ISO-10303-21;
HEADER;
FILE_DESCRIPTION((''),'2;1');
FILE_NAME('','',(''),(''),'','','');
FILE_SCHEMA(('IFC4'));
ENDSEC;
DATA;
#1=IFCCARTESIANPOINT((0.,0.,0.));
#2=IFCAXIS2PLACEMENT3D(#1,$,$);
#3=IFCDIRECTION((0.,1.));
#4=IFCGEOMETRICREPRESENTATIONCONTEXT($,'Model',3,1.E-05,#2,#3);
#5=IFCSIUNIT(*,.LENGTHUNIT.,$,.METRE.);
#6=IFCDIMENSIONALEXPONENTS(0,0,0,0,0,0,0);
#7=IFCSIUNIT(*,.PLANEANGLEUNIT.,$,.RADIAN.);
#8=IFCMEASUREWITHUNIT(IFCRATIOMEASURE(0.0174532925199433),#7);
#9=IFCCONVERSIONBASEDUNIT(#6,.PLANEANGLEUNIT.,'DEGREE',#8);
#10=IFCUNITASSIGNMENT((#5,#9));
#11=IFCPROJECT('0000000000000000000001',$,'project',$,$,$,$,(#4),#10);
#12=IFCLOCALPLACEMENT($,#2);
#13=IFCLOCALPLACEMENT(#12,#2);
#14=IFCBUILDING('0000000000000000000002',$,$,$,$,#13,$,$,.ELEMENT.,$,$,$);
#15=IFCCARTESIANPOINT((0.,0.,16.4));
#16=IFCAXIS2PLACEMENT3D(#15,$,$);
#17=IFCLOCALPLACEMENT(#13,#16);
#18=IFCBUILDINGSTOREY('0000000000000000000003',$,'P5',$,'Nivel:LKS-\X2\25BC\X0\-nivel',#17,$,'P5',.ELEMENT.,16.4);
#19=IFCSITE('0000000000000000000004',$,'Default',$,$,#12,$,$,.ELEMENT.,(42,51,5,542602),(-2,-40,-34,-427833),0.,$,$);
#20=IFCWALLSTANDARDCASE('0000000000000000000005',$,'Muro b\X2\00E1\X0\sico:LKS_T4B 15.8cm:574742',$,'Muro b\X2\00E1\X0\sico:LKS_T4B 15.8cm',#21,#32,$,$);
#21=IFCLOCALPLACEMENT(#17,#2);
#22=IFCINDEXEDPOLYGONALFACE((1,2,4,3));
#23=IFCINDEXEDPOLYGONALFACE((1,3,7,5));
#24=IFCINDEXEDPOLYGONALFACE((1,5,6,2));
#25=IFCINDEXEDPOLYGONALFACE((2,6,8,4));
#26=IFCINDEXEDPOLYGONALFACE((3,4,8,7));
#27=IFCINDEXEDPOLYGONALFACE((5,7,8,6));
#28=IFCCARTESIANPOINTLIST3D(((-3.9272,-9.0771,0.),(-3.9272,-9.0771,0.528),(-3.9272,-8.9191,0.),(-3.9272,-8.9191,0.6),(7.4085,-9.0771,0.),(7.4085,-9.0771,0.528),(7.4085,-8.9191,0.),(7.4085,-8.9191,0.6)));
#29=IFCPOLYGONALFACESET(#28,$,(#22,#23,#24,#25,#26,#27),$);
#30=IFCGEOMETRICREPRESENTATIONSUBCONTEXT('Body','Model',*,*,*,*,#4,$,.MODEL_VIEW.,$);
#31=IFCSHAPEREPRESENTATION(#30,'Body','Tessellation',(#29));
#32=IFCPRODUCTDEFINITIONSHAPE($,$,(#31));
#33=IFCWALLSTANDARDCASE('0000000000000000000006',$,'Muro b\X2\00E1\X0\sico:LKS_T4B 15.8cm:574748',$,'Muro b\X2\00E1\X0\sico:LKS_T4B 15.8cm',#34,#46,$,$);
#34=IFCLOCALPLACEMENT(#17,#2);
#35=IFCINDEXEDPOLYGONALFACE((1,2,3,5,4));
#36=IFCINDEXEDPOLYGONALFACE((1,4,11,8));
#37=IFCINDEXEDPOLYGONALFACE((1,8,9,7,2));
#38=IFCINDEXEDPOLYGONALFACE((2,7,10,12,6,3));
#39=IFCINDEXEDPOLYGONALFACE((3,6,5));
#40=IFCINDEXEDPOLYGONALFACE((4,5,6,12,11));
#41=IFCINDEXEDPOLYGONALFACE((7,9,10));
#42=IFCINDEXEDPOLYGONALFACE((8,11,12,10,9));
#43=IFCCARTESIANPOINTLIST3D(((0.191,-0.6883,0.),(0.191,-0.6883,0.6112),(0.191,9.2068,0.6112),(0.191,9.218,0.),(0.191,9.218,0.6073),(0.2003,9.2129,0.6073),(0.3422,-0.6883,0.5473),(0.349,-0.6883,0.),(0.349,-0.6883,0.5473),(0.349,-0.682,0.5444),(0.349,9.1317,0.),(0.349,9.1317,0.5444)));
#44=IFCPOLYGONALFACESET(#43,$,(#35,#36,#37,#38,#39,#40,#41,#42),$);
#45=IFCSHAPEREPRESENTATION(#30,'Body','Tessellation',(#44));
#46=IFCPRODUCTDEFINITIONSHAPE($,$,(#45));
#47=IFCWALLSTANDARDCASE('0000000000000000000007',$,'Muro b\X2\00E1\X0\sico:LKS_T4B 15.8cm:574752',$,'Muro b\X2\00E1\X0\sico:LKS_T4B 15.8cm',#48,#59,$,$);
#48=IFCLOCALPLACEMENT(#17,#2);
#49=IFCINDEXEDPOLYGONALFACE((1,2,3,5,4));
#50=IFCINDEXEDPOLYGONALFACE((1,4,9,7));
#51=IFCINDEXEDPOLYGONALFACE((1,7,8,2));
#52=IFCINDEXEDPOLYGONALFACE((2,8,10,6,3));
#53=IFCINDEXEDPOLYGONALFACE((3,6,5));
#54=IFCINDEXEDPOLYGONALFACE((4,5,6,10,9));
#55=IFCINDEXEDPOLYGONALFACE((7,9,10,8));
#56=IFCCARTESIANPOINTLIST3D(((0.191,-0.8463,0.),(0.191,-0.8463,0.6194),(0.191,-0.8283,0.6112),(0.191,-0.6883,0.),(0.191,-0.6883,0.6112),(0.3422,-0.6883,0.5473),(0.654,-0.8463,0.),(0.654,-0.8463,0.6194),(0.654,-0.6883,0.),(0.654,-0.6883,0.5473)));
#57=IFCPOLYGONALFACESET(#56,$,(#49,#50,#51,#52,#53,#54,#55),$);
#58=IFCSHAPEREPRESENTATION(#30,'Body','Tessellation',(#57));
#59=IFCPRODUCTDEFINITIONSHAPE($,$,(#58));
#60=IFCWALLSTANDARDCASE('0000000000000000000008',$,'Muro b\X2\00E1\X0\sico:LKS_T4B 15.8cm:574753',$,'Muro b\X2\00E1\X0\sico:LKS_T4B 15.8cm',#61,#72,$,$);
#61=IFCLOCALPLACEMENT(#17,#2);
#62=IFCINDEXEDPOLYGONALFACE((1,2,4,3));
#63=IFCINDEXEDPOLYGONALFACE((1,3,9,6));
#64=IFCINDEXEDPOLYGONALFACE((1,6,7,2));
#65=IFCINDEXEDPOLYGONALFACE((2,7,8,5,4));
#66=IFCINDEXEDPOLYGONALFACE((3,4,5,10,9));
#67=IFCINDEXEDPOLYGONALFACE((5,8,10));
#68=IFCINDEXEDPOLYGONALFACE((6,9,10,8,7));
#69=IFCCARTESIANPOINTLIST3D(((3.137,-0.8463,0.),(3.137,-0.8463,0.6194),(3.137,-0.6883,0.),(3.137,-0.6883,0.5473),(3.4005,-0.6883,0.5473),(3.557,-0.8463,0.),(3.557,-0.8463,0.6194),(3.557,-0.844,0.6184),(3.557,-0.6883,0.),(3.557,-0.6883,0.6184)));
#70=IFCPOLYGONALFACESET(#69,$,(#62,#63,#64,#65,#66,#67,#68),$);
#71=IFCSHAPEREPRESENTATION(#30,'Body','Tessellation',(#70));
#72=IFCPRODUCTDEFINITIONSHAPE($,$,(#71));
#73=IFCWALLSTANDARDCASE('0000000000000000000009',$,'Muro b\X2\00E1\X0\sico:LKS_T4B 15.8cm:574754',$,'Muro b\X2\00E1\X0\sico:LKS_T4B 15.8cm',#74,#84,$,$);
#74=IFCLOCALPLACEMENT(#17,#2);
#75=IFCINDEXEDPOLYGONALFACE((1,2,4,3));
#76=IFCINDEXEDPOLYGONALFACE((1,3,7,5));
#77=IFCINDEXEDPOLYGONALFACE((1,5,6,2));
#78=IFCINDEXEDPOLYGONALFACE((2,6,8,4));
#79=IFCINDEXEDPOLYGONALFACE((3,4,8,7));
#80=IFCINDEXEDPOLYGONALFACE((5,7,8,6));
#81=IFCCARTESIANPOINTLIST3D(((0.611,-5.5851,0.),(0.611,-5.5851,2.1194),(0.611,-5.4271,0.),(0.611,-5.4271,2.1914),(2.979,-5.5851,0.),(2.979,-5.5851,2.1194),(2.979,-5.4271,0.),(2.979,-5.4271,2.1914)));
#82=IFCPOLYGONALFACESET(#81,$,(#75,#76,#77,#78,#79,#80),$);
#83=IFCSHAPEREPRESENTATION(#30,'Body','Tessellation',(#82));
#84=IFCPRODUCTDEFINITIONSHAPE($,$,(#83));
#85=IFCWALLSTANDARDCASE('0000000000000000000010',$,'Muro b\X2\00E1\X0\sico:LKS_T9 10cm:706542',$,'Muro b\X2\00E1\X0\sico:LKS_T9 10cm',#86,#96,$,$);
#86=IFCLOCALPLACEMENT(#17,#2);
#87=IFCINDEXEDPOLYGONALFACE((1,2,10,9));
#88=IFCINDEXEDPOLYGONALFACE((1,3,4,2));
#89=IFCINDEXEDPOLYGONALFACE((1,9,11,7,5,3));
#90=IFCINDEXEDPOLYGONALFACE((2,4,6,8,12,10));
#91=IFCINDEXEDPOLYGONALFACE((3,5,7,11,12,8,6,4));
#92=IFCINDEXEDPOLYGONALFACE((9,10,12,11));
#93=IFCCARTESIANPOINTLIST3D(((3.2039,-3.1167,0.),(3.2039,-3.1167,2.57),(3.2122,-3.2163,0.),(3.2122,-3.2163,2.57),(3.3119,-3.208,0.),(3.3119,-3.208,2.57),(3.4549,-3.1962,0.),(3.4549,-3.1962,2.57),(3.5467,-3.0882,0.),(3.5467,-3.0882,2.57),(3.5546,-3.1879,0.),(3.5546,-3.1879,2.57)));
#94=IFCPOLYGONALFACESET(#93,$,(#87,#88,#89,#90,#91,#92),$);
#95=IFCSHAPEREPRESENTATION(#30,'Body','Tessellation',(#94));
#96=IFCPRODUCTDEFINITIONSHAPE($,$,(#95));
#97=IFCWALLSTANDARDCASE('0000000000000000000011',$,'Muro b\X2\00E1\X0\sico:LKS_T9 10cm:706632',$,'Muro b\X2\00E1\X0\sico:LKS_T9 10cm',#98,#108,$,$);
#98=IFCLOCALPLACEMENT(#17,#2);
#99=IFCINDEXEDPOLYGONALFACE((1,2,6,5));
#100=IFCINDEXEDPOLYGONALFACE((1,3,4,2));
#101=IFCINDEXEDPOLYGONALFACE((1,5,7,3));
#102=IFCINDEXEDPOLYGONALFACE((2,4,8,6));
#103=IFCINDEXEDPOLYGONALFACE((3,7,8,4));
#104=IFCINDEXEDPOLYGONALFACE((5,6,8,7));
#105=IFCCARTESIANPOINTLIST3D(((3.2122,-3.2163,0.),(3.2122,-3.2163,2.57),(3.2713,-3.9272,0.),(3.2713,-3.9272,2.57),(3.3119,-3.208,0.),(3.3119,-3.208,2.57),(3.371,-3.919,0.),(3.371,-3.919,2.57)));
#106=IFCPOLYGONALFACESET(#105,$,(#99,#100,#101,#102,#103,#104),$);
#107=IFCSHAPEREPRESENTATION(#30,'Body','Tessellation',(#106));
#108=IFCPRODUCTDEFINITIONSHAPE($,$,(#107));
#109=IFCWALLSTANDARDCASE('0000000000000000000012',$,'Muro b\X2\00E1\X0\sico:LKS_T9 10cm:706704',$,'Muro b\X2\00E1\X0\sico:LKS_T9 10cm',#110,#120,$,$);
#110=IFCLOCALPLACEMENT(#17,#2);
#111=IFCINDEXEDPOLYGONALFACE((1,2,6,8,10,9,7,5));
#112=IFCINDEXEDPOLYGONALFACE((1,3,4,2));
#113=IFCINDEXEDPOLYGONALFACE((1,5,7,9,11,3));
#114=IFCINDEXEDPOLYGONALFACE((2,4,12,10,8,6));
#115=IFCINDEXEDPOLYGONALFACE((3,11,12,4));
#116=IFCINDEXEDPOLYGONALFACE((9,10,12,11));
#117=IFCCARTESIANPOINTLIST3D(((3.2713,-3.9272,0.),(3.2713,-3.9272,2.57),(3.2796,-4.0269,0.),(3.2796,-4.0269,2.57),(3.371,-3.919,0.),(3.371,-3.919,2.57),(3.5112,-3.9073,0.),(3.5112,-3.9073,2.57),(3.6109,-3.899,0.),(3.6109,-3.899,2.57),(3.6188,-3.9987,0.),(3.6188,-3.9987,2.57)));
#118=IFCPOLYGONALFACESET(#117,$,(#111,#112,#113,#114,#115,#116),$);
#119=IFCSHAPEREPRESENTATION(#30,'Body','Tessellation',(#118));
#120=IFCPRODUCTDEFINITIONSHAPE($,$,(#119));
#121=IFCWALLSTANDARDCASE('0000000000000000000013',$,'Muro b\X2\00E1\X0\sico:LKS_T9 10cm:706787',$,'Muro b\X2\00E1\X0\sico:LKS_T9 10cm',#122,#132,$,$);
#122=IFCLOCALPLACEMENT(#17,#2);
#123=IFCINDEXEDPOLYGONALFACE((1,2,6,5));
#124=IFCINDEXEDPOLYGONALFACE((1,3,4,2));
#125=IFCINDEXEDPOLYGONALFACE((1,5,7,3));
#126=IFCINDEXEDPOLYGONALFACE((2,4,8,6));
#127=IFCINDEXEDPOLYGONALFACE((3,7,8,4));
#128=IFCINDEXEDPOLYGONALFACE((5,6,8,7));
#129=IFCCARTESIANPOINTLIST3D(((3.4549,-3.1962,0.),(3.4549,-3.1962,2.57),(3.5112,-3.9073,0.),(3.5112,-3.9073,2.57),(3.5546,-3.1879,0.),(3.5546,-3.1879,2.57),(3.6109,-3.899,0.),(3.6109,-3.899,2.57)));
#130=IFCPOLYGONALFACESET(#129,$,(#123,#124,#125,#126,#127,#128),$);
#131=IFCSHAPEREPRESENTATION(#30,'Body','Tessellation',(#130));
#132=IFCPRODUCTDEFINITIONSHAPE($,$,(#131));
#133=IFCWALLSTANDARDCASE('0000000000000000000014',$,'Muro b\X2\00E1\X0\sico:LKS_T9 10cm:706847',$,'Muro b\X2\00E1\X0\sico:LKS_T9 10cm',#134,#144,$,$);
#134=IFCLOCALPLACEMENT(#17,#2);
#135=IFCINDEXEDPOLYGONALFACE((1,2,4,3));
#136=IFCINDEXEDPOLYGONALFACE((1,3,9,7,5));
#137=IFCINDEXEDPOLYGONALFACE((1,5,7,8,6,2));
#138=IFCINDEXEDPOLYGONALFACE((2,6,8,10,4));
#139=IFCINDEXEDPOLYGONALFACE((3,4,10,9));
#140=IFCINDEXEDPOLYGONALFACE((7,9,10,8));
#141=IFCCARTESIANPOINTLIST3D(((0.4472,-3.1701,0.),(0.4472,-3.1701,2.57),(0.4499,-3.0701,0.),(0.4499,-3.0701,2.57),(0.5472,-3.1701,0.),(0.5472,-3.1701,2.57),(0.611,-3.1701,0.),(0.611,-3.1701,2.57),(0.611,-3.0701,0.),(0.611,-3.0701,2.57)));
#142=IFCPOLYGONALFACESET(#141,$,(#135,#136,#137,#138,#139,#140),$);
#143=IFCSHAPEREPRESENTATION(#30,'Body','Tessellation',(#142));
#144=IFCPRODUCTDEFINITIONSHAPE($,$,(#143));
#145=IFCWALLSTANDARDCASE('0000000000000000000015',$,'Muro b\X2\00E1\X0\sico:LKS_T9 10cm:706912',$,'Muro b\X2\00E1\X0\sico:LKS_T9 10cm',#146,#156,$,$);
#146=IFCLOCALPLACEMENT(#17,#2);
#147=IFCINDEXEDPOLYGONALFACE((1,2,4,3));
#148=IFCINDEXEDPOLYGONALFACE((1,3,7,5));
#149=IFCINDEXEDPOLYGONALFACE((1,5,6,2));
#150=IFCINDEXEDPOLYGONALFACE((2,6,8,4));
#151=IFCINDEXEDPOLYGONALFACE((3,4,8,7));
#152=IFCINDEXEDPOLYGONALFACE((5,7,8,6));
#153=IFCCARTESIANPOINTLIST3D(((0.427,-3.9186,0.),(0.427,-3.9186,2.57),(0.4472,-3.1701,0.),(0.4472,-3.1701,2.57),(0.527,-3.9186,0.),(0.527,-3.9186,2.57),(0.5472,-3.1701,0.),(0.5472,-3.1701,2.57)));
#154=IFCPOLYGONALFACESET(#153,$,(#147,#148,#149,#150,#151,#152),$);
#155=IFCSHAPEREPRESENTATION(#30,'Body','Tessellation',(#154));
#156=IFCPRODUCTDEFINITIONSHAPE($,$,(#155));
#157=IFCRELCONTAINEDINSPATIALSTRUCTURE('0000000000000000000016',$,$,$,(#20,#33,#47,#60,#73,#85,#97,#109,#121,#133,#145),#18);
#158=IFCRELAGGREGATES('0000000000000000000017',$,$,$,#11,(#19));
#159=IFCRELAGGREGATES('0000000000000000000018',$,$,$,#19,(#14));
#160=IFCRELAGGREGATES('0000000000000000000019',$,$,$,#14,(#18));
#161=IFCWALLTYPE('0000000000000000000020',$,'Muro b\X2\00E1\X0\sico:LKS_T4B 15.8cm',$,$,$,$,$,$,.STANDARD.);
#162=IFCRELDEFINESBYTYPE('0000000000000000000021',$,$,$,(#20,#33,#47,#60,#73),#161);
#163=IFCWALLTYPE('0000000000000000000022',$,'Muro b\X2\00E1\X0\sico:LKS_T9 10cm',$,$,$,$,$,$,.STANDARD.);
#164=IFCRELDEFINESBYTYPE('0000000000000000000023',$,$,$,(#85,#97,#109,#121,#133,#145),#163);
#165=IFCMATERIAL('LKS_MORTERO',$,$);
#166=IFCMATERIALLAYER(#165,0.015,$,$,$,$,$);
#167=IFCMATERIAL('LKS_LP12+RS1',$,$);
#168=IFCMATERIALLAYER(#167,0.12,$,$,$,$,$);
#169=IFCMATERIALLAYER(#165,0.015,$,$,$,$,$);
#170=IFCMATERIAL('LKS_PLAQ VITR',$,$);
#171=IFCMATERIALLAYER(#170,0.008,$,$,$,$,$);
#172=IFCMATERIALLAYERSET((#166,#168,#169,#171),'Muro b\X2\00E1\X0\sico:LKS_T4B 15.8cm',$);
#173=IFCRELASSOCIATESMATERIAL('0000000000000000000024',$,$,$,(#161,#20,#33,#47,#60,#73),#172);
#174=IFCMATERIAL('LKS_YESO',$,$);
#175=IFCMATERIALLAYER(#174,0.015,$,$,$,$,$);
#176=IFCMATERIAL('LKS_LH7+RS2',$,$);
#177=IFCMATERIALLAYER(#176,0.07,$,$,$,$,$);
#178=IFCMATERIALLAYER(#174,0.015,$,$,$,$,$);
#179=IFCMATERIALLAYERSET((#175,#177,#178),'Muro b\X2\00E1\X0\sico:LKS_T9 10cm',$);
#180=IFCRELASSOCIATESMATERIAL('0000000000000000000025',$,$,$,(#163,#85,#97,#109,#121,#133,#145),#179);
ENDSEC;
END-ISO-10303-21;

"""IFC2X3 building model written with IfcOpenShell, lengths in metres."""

from ifc_helpers import new_model, entity, si_unit, converted_unit, direction, frame, frame_2d, origin, place, context, subcontext, project, spatial, polyline, rectangle, outline, extrude, clip, bounded_halfspace, material, layer, layer_set, layer_usage, type_object, element, save


model = new_model("IFC2X3")

# Units and contexts
model_context = context("Model", 3, precision=1e-05, world=origin(), true_north=direction((0.0, 1.0)))
body_context = subcontext(model_context, "Body", "Model", "MODEL_VIEW")
ifc_project = project(units=[si_unit("LENGTHUNIT", "METRE"), converted_unit("PLANEANGLEUNIT", "DEGREE", entity("IfcRatioMeasure", 0.0174532925199433), si_unit("PLANEANGLEUNIT", "RADIAN"), dimensions=[0, 0, 0, 0, 0, 0, 0])], contexts=[model_context])

# Site, building, storey
site_placement = place(None, origin())
site = spatial("IfcSite", under=ifc_project, at=site_placement, Name="Default", CompositionType="ELEMENT", RefLatitude=(42, 51, 5, 542602), RefLongitude=(-2, -40, -34, -427833), RefElevation=0.0)
building_placement = place(site_placement, origin())
building = spatial("IfcBuilding", under=site, at=building_placement, CompositionType="ELEMENT")
storey_placement = place(building_placement, frame((0.0, 0.0, 16.4)))
storey = spatial("IfcBuildingStorey", under=building, at=storey_placement, Name="P5", ObjectType="Nivel:LKS-▼-nivel", LongName="P5", CompositionType="ELEMENT", Elevation=16.4)

# Shared definitions
ifc_material_1 = material(Name="LKS_MORTERO")
ifc_material_2 = material(Name="LKS_YESO")

# Walls
ifc_layer_1 = layer(ifc_material_1, 0.015)
ifc_material_3 = material(Name="LKS_LP12+RS1")
ifc_layer_2 = layer(ifc_material_3, 0.12)
ifc_layer_3 = layer(ifc_material_1, 0.015)
ifc_material_4 = material(Name="LKS_PLAQ VITR")
ifc_layer_4 = layer(ifc_material_4, 0.008)
ifc_layer_set_1 = layer_set([ifc_layer_1, ifc_layer_2, ifc_layer_3, ifc_layer_4], Name="Muro básico:LKS_T4B 15.8cm")
ifc_layer_usage_1 = layer_usage(ifc_layer_set_1, "AXIS2", "POSITIVE", -0.079)
wall_type_1 = type_object("IfcWallType", Name="Muro básico:LKS_T4B 15.8cm", PredefinedType="STANDARD", material=ifc_layer_set_1)
wall_1_placement = place(storey_placement, frame((-3.9272, -8.9981, 0.0)))
element("IfcWallStandardCase", 1, at=wall_1_placement, inside=storey, type_object=wall_type_1, material=ifc_layer_usage_1, Name="Muro básico:LKS_T4B 15.8cm:574742", ObjectType="Muro básico:LKS_T4B 15.8cm", context=body_context, shape_type="Clipping", body=[
    clip(extrude(rectangle(XDim=11.3357, YDim=0.158, at=frame_2d((5.6679, 0.0), x_axis=(-1.0, 0.0))), origin(), (0.0, 0.0, 1.0), 0.6), bounded_halfspace(frame((0.0, -0.079, 0.528), z_axis=(0.0, -0.414693, 0.909961), x_axis=(1.0, 0.0, 0.0)), False, frame((0.0, -0.079, 0.528)), polyline([(0.0, 0.0), (11.3357, 0.0), (11.3357, 0.158), (0.158, 0.158), (0.0, 0.158), (0.0, 0.0)]))),
])
ifc_layer_usage_2 = layer_usage(ifc_layer_set_1, "AXIS2", "NEGATIVE", 0.079)
wall_2_placement = place(storey_placement, frame((0.27, -0.6883, 0.0), z_axis=(0.0, 0.0, 1.0), x_axis=(0.0, 1.0, 0.0)))
element("IfcWallStandardCase", 2, at=wall_2_placement, inside=storey, type_object=wall_type_1, material=ifc_layer_usage_2, Name="Muro básico:LKS_T4B 15.8cm:574748", ObjectType="Muro básico:LKS_T4B 15.8cm", context=body_context, shape_type="Clipping", body=[
    clip(clip(clip(extrude(outline(polyline([(9.8199, -0.079), (9.9063, 0.079), (0.0, 0.079), (0.0, -0.079), (4.8711, -0.079), (5.2711, -0.079), (5.5511, -0.079), (9.8199, -0.079)])), origin(), (0.0, 0.0, 1.0), 0.6112), bounded_halfspace(frame((9.9012, 0.0696, 0.6073), z_axis=(0.328721, -0.179647, 0.927184), x_axis=(0.479561, 0.877509, 0.0)), False, frame((9.9012, 0.0696, 0.6073)), polyline([(0.0, 0.0), (0.0051, 0.0094), (-0.0061, 0.0094), (0.0, 0.0)]))), bounded_halfspace(frame((0.0063, -0.079, 0.5444), z_axis=(0.0, -0.389514, 0.921021), x_axis=(1.0, 0.0, 0.0)), False, frame((0.0063, -0.079, 0.5444)), polyline([(0.0, 0.0), (9.8137, 0.0), (9.8949, 0.1486), (9.8888, 0.158), (-0.0063, 0.158), (-0.0063, 0.0068), (0.0, 0.0)]))), bounded_halfspace(frame((0.0, -0.079, 0.5473), z_axis=(0.415328, 0.0, 0.909672), x_axis=(0.0, 1.0, 0.0)), False, frame((0.0, -0.079, 0.5473)), polyline([(0.0, 0.0), (0.0063, 0.0), (0.0, 0.0068), (0.0, 0.0)]))),
])
ifc_layer_usage_3 = layer_usage(ifc_layer_set_1, "AXIS2", "NEGATIVE", 0.079)
wall_3_placement = place(storey_placement, frame((0.191, -0.7673, 0.0)))
element("IfcWallStandardCase", 3, at=wall_3_placement, inside=storey, type_object=wall_type_1, material=ifc_layer_usage_3, Name="Muro básico:LKS_T4B 15.8cm:574752", ObjectType="Muro básico:LKS_T4B 15.8cm", context=body_context, shape_type="Clipping", body=[
    clip(clip(extrude(rectangle(XDim=0.463, YDim=0.158, at=frame_2d((0.2315, 0.0), x_axis=(-1.0, 0.0))), origin(), (0.0, 0.0, 1.0), 0.6194), bounded_halfspace(frame((0.1512, 0.079, 0.5473), z_axis=(0.389514, 0.0, 0.921021), x_axis=(0.0, 1.0, 0.0)), False, frame((0.1512, 0.079, 0.5473)), polyline([(0.0, 0.0), (-0.1512, 0.0), (-0.1512, -0.1401), (0.0, 0.0)]))), bounded_halfspace(frame((0.0, -0.079, 0.6194), z_axis=(0.0, 0.415328, 0.909672), x_axis=(-1.0, 0.0, 0.0)), False, frame((0.0, -0.079, 0.6194)), polyline([(0.0, 0.0), (0.158, 0.0), (0.463, 0.0), (0.463, 0.158), (0.158, 0.158), (0.1512, 0.158), (0.0, 0.0179), (0.0, 0.0)]))),
])
ifc_layer_usage_4 = layer_usage(ifc_layer_set_1, "AXIS2", "POSITIVE", -0.079)
wall_4_placement = place(storey_placement, frame((3.557, -0.7673, 0.0), z_axis=(0.0, 0.0, 1.0), x_axis=(-1.0, 0.0, 0.0)))
element("IfcWallStandardCase", 4, at=wall_4_placement, inside=storey, type_object=wall_type_1, material=ifc_layer_usage_4, Name="Muro básico:LKS_T4B 15.8cm:574753", ObjectType="Muro básico:LKS_T4B 15.8cm", context=body_context, shape_type="Clipping", body=[
    clip(clip(extrude(rectangle(XDim=0.42, YDim=0.158, at=frame_2d((0.21, 0.0), x_axis=(-1.0, 0.0))), origin(), (0.0, 0.0, 1.0), 0.6194), bounded_halfspace(frame((0.0, -0.079, 0.6184), z_axis=(0.413605, 0.0, 0.910456), x_axis=(0.0, 1.0, 0.0)), False, frame((0.0, -0.079, 0.6184)), polyline([(0.0, 0.0), (0.1565, 0.0), (0.0, 0.1557), (0.0, 0.0)]))), bounded_halfspace(frame((0.1565, -0.079, 0.5473), z_axis=(0.0, -0.415328, 0.909672), x_axis=(1.0, 0.0, 0.0)), False, frame((0.1565, -0.079, 0.5473)), polyline([(0.0, 0.0), (0.0015, 0.0), (0.2635, 0.0), (0.2635, 0.158), (0.0015, 0.158), (-0.1565, 0.158), (-0.1565, 0.1557), (0.0, 0.0)]))),
])
ifc_layer_usage_5 = layer_usage(ifc_layer_set_1, "AXIS2", "POSITIVE", -0.079)
wall_5_placement = place(storey_placement, frame((2.979, -5.5061, 0.0), z_axis=(0.0, 0.0, 1.0), x_axis=(-1.0, 0.0, 0.0)))
element("IfcWallStandardCase", 5, at=wall_5_placement, inside=storey, type_object=wall_type_1, material=ifc_layer_usage_5, Name="Muro básico:LKS_T4B 15.8cm:574754", ObjectType="Muro básico:LKS_T4B 15.8cm", context=body_context, shape_type="Clipping", body=[
    clip(extrude(rectangle(XDim=2.368, YDim=0.158, at=frame_2d((1.184, 0.0), x_axis=(-1.0, 0.0))), origin(), (0.0, 0.0, 1.0), 2.1914), bounded_halfspace(frame((0.0, -0.079, 2.1914), z_axis=(0.0, 0.414693, 0.909961), x_axis=(-1.0, 0.0, 0.0)), False, frame((0.0, -0.079, 2.1914)), polyline([(0.0, 0.0), (2.368, 0.0), (2.368, 0.158), (0.0, 0.158), (0.0, 0.0)]))),
])
ifc_layer_5 = layer(ifc_material_2, 0.015)
ifc_material_5 = material(Name="LKS_LH7+RS2")
ifc_layer_6 = layer(ifc_material_5, 0.07)
ifc_layer_7 = layer(ifc_material_2, 0.015)
ifc_layer_set_2 = layer_set([ifc_layer_5, ifc_layer_6, ifc_layer_7], Name="Muro básico:LKS_T9 10cm")
ifc_layer_usage_6 = layer_usage(ifc_layer_set_2, "AXIS2", "POSITIVE", -0.05)
wall_type_2 = type_object("IfcWallType", Name="Muro básico:LKS_T9 10cm", PredefinedType="STANDARD", material=ifc_layer_set_2)
wall_6_placement = place(storey_placement, frame((3.5508, -3.138, 0.0), z_axis=(0.0, 0.0, 1.0), x_axis=(-0.996566, -0.082798, 0.0)))
element("IfcWallStandardCase", 6, at=wall_6_placement, inside=storey, type_object=wall_type_2, material=ifc_layer_usage_6, Name="Muro básico:LKS_T9 10cm:706542", ObjectType="Muro básico:LKS_T9 10cm", context=body_context, shape_type="SweptSolid", body=[
    extrude(outline(polyline([(0.3439, -0.05), (0.3439, 0.05), (0.2439, 0.05), (0.1004, 0.05), (0.0004, 0.05), (0.0, -0.05), (0.3439, -0.05)])), origin(), (0.0, 0.0, 1.0), 2.57),
])
ifc_layer_usage_7 = layer_usage(ifc_layer_set_2, "AXIS2", "POSITIVE", -0.05)
wall_7_placement = place(storey_placement, frame((3.2621, -3.2122, 0.0), z_axis=(0.0, 0.0, 1.0), x_axis=(0.082798, -0.996566, 0.0)))
element("IfcWallStandardCase", 7, at=wall_7_placement, inside=storey, type_object=wall_type_2, material=ifc_layer_usage_7, Name="Muro básico:LKS_T9 10cm:706632", ObjectType="Muro básico:LKS_T9 10cm", context=body_context, shape_type="SweptSolid", body=[
    extrude(rectangle(XDim=0.7134, YDim=0.1, at=frame_2d((0.3567, 0.0), x_axis=(-1.0, 0.0))), origin(), (0.0, 0.0, 1.0), 2.57),
])
ifc_layer_usage_8 = layer_usage(ifc_layer_set_2, "AXIS2", "POSITIVE", -0.05)
wall_8_placement = place(storey_placement, frame((3.2754, -3.9771, 0.0), z_axis=(0.0, 0.0, 1.0), x_axis=(0.996566, 0.082798, 0.0)))
element("IfcWallStandardCase", 8, at=wall_8_placement, inside=storey, type_object=wall_type_2, material=ifc_layer_usage_8, Name="Muro básico:LKS_T9 10cm:706704", ObjectType="Muro básico:LKS_T9 10cm", context=body_context, shape_type="SweptSolid", body=[
    extrude(outline(polyline([(0.3404, -0.05), (0.3408, 0.05), (0.2408, 0.05), (0.1, 0.05), (0.0, 0.05), (0.0, -0.05), (0.3404, -0.05)])), origin(), (0.0, 0.0, 1.0), 2.57),
])
ifc_layer_usage_9 = layer_usage(ifc_layer_set_2, "AXIS2", "POSITIVE", -0.05)
wall_9_placement = place(storey_placement, frame((3.5611, -3.9033, 0.0), z_axis=(0.0, 0.0, 1.0), x_axis=(-0.078975, 0.996877, 0.0)))
element("IfcWallStandardCase", 9, at=wall_9_placement, inside=storey, type_object=wall_type_2, material=ifc_layer_usage_9, Name="Muro básico:LKS_T9 10cm:706787", ObjectType="Muro básico:LKS_T9 10cm", context=body_context, shape_type="SweptSolid", body=[
    extrude(outline(polyline([(0.7138, -0.05), (0.7134, 0.05), (0.0, 0.05), (0.0004, -0.05), (0.7138, -0.05)])), origin(), (0.0, 0.0, 1.0), 2.57),
])
ifc_layer_usage_10 = layer_usage(ifc_layer_set_2, "AXIS2", "POSITIVE", -0.05)
wall_10_placement = place(storey_placement, frame((0.611, -3.1201, 0.0), z_axis=(0.0, 0.0, 1.0), x_axis=(-1.0, 0.0, 0.0)))
element("IfcWallStandardCase", 10, at=wall_10_placement, inside=storey, type_object=wall_type_2, material=ifc_layer_usage_10, Name="Muro básico:LKS_T9 10cm:706847", ObjectType="Muro básico:LKS_T9 10cm", context=body_context, shape_type="SweptSolid", body=[
    extrude(outline(polyline([(0.1611, -0.05), (0.1638, 0.05), (0.0637, 0.05), (0.0, 0.05), (0.0, -0.05), (0.1611, -0.05)])), origin(), (0.0, 0.0, 1.0), 2.57),
])
ifc_layer_usage_11 = layer_usage(ifc_layer_set_2, "AXIS2", "POSITIVE", -0.05)
wall_11_placement = place(storey_placement, frame((0.4972, -3.1688, 0.0), z_axis=(0.0, 0.0, 1.0), x_axis=(-0.026991, -0.999636, 0.0)))
element("IfcWallStandardCase", 11, at=wall_11_placement, inside=storey, type_object=wall_type_2, material=ifc_layer_usage_11, Name="Muro básico:LKS_T9 10cm:706912", ObjectType="Muro básico:LKS_T9 10cm", context=body_context, shape_type="SweptSolid", body=[
    extrude(outline(polyline([(0.7514, -0.05), (0.7487, 0.05), (0.0, 0.05), (0.0027, -0.05), (0.7514, -0.05)])), origin(), (0.0, 0.0, 1.0), 2.57),
])

save(model, "model.ifc")
